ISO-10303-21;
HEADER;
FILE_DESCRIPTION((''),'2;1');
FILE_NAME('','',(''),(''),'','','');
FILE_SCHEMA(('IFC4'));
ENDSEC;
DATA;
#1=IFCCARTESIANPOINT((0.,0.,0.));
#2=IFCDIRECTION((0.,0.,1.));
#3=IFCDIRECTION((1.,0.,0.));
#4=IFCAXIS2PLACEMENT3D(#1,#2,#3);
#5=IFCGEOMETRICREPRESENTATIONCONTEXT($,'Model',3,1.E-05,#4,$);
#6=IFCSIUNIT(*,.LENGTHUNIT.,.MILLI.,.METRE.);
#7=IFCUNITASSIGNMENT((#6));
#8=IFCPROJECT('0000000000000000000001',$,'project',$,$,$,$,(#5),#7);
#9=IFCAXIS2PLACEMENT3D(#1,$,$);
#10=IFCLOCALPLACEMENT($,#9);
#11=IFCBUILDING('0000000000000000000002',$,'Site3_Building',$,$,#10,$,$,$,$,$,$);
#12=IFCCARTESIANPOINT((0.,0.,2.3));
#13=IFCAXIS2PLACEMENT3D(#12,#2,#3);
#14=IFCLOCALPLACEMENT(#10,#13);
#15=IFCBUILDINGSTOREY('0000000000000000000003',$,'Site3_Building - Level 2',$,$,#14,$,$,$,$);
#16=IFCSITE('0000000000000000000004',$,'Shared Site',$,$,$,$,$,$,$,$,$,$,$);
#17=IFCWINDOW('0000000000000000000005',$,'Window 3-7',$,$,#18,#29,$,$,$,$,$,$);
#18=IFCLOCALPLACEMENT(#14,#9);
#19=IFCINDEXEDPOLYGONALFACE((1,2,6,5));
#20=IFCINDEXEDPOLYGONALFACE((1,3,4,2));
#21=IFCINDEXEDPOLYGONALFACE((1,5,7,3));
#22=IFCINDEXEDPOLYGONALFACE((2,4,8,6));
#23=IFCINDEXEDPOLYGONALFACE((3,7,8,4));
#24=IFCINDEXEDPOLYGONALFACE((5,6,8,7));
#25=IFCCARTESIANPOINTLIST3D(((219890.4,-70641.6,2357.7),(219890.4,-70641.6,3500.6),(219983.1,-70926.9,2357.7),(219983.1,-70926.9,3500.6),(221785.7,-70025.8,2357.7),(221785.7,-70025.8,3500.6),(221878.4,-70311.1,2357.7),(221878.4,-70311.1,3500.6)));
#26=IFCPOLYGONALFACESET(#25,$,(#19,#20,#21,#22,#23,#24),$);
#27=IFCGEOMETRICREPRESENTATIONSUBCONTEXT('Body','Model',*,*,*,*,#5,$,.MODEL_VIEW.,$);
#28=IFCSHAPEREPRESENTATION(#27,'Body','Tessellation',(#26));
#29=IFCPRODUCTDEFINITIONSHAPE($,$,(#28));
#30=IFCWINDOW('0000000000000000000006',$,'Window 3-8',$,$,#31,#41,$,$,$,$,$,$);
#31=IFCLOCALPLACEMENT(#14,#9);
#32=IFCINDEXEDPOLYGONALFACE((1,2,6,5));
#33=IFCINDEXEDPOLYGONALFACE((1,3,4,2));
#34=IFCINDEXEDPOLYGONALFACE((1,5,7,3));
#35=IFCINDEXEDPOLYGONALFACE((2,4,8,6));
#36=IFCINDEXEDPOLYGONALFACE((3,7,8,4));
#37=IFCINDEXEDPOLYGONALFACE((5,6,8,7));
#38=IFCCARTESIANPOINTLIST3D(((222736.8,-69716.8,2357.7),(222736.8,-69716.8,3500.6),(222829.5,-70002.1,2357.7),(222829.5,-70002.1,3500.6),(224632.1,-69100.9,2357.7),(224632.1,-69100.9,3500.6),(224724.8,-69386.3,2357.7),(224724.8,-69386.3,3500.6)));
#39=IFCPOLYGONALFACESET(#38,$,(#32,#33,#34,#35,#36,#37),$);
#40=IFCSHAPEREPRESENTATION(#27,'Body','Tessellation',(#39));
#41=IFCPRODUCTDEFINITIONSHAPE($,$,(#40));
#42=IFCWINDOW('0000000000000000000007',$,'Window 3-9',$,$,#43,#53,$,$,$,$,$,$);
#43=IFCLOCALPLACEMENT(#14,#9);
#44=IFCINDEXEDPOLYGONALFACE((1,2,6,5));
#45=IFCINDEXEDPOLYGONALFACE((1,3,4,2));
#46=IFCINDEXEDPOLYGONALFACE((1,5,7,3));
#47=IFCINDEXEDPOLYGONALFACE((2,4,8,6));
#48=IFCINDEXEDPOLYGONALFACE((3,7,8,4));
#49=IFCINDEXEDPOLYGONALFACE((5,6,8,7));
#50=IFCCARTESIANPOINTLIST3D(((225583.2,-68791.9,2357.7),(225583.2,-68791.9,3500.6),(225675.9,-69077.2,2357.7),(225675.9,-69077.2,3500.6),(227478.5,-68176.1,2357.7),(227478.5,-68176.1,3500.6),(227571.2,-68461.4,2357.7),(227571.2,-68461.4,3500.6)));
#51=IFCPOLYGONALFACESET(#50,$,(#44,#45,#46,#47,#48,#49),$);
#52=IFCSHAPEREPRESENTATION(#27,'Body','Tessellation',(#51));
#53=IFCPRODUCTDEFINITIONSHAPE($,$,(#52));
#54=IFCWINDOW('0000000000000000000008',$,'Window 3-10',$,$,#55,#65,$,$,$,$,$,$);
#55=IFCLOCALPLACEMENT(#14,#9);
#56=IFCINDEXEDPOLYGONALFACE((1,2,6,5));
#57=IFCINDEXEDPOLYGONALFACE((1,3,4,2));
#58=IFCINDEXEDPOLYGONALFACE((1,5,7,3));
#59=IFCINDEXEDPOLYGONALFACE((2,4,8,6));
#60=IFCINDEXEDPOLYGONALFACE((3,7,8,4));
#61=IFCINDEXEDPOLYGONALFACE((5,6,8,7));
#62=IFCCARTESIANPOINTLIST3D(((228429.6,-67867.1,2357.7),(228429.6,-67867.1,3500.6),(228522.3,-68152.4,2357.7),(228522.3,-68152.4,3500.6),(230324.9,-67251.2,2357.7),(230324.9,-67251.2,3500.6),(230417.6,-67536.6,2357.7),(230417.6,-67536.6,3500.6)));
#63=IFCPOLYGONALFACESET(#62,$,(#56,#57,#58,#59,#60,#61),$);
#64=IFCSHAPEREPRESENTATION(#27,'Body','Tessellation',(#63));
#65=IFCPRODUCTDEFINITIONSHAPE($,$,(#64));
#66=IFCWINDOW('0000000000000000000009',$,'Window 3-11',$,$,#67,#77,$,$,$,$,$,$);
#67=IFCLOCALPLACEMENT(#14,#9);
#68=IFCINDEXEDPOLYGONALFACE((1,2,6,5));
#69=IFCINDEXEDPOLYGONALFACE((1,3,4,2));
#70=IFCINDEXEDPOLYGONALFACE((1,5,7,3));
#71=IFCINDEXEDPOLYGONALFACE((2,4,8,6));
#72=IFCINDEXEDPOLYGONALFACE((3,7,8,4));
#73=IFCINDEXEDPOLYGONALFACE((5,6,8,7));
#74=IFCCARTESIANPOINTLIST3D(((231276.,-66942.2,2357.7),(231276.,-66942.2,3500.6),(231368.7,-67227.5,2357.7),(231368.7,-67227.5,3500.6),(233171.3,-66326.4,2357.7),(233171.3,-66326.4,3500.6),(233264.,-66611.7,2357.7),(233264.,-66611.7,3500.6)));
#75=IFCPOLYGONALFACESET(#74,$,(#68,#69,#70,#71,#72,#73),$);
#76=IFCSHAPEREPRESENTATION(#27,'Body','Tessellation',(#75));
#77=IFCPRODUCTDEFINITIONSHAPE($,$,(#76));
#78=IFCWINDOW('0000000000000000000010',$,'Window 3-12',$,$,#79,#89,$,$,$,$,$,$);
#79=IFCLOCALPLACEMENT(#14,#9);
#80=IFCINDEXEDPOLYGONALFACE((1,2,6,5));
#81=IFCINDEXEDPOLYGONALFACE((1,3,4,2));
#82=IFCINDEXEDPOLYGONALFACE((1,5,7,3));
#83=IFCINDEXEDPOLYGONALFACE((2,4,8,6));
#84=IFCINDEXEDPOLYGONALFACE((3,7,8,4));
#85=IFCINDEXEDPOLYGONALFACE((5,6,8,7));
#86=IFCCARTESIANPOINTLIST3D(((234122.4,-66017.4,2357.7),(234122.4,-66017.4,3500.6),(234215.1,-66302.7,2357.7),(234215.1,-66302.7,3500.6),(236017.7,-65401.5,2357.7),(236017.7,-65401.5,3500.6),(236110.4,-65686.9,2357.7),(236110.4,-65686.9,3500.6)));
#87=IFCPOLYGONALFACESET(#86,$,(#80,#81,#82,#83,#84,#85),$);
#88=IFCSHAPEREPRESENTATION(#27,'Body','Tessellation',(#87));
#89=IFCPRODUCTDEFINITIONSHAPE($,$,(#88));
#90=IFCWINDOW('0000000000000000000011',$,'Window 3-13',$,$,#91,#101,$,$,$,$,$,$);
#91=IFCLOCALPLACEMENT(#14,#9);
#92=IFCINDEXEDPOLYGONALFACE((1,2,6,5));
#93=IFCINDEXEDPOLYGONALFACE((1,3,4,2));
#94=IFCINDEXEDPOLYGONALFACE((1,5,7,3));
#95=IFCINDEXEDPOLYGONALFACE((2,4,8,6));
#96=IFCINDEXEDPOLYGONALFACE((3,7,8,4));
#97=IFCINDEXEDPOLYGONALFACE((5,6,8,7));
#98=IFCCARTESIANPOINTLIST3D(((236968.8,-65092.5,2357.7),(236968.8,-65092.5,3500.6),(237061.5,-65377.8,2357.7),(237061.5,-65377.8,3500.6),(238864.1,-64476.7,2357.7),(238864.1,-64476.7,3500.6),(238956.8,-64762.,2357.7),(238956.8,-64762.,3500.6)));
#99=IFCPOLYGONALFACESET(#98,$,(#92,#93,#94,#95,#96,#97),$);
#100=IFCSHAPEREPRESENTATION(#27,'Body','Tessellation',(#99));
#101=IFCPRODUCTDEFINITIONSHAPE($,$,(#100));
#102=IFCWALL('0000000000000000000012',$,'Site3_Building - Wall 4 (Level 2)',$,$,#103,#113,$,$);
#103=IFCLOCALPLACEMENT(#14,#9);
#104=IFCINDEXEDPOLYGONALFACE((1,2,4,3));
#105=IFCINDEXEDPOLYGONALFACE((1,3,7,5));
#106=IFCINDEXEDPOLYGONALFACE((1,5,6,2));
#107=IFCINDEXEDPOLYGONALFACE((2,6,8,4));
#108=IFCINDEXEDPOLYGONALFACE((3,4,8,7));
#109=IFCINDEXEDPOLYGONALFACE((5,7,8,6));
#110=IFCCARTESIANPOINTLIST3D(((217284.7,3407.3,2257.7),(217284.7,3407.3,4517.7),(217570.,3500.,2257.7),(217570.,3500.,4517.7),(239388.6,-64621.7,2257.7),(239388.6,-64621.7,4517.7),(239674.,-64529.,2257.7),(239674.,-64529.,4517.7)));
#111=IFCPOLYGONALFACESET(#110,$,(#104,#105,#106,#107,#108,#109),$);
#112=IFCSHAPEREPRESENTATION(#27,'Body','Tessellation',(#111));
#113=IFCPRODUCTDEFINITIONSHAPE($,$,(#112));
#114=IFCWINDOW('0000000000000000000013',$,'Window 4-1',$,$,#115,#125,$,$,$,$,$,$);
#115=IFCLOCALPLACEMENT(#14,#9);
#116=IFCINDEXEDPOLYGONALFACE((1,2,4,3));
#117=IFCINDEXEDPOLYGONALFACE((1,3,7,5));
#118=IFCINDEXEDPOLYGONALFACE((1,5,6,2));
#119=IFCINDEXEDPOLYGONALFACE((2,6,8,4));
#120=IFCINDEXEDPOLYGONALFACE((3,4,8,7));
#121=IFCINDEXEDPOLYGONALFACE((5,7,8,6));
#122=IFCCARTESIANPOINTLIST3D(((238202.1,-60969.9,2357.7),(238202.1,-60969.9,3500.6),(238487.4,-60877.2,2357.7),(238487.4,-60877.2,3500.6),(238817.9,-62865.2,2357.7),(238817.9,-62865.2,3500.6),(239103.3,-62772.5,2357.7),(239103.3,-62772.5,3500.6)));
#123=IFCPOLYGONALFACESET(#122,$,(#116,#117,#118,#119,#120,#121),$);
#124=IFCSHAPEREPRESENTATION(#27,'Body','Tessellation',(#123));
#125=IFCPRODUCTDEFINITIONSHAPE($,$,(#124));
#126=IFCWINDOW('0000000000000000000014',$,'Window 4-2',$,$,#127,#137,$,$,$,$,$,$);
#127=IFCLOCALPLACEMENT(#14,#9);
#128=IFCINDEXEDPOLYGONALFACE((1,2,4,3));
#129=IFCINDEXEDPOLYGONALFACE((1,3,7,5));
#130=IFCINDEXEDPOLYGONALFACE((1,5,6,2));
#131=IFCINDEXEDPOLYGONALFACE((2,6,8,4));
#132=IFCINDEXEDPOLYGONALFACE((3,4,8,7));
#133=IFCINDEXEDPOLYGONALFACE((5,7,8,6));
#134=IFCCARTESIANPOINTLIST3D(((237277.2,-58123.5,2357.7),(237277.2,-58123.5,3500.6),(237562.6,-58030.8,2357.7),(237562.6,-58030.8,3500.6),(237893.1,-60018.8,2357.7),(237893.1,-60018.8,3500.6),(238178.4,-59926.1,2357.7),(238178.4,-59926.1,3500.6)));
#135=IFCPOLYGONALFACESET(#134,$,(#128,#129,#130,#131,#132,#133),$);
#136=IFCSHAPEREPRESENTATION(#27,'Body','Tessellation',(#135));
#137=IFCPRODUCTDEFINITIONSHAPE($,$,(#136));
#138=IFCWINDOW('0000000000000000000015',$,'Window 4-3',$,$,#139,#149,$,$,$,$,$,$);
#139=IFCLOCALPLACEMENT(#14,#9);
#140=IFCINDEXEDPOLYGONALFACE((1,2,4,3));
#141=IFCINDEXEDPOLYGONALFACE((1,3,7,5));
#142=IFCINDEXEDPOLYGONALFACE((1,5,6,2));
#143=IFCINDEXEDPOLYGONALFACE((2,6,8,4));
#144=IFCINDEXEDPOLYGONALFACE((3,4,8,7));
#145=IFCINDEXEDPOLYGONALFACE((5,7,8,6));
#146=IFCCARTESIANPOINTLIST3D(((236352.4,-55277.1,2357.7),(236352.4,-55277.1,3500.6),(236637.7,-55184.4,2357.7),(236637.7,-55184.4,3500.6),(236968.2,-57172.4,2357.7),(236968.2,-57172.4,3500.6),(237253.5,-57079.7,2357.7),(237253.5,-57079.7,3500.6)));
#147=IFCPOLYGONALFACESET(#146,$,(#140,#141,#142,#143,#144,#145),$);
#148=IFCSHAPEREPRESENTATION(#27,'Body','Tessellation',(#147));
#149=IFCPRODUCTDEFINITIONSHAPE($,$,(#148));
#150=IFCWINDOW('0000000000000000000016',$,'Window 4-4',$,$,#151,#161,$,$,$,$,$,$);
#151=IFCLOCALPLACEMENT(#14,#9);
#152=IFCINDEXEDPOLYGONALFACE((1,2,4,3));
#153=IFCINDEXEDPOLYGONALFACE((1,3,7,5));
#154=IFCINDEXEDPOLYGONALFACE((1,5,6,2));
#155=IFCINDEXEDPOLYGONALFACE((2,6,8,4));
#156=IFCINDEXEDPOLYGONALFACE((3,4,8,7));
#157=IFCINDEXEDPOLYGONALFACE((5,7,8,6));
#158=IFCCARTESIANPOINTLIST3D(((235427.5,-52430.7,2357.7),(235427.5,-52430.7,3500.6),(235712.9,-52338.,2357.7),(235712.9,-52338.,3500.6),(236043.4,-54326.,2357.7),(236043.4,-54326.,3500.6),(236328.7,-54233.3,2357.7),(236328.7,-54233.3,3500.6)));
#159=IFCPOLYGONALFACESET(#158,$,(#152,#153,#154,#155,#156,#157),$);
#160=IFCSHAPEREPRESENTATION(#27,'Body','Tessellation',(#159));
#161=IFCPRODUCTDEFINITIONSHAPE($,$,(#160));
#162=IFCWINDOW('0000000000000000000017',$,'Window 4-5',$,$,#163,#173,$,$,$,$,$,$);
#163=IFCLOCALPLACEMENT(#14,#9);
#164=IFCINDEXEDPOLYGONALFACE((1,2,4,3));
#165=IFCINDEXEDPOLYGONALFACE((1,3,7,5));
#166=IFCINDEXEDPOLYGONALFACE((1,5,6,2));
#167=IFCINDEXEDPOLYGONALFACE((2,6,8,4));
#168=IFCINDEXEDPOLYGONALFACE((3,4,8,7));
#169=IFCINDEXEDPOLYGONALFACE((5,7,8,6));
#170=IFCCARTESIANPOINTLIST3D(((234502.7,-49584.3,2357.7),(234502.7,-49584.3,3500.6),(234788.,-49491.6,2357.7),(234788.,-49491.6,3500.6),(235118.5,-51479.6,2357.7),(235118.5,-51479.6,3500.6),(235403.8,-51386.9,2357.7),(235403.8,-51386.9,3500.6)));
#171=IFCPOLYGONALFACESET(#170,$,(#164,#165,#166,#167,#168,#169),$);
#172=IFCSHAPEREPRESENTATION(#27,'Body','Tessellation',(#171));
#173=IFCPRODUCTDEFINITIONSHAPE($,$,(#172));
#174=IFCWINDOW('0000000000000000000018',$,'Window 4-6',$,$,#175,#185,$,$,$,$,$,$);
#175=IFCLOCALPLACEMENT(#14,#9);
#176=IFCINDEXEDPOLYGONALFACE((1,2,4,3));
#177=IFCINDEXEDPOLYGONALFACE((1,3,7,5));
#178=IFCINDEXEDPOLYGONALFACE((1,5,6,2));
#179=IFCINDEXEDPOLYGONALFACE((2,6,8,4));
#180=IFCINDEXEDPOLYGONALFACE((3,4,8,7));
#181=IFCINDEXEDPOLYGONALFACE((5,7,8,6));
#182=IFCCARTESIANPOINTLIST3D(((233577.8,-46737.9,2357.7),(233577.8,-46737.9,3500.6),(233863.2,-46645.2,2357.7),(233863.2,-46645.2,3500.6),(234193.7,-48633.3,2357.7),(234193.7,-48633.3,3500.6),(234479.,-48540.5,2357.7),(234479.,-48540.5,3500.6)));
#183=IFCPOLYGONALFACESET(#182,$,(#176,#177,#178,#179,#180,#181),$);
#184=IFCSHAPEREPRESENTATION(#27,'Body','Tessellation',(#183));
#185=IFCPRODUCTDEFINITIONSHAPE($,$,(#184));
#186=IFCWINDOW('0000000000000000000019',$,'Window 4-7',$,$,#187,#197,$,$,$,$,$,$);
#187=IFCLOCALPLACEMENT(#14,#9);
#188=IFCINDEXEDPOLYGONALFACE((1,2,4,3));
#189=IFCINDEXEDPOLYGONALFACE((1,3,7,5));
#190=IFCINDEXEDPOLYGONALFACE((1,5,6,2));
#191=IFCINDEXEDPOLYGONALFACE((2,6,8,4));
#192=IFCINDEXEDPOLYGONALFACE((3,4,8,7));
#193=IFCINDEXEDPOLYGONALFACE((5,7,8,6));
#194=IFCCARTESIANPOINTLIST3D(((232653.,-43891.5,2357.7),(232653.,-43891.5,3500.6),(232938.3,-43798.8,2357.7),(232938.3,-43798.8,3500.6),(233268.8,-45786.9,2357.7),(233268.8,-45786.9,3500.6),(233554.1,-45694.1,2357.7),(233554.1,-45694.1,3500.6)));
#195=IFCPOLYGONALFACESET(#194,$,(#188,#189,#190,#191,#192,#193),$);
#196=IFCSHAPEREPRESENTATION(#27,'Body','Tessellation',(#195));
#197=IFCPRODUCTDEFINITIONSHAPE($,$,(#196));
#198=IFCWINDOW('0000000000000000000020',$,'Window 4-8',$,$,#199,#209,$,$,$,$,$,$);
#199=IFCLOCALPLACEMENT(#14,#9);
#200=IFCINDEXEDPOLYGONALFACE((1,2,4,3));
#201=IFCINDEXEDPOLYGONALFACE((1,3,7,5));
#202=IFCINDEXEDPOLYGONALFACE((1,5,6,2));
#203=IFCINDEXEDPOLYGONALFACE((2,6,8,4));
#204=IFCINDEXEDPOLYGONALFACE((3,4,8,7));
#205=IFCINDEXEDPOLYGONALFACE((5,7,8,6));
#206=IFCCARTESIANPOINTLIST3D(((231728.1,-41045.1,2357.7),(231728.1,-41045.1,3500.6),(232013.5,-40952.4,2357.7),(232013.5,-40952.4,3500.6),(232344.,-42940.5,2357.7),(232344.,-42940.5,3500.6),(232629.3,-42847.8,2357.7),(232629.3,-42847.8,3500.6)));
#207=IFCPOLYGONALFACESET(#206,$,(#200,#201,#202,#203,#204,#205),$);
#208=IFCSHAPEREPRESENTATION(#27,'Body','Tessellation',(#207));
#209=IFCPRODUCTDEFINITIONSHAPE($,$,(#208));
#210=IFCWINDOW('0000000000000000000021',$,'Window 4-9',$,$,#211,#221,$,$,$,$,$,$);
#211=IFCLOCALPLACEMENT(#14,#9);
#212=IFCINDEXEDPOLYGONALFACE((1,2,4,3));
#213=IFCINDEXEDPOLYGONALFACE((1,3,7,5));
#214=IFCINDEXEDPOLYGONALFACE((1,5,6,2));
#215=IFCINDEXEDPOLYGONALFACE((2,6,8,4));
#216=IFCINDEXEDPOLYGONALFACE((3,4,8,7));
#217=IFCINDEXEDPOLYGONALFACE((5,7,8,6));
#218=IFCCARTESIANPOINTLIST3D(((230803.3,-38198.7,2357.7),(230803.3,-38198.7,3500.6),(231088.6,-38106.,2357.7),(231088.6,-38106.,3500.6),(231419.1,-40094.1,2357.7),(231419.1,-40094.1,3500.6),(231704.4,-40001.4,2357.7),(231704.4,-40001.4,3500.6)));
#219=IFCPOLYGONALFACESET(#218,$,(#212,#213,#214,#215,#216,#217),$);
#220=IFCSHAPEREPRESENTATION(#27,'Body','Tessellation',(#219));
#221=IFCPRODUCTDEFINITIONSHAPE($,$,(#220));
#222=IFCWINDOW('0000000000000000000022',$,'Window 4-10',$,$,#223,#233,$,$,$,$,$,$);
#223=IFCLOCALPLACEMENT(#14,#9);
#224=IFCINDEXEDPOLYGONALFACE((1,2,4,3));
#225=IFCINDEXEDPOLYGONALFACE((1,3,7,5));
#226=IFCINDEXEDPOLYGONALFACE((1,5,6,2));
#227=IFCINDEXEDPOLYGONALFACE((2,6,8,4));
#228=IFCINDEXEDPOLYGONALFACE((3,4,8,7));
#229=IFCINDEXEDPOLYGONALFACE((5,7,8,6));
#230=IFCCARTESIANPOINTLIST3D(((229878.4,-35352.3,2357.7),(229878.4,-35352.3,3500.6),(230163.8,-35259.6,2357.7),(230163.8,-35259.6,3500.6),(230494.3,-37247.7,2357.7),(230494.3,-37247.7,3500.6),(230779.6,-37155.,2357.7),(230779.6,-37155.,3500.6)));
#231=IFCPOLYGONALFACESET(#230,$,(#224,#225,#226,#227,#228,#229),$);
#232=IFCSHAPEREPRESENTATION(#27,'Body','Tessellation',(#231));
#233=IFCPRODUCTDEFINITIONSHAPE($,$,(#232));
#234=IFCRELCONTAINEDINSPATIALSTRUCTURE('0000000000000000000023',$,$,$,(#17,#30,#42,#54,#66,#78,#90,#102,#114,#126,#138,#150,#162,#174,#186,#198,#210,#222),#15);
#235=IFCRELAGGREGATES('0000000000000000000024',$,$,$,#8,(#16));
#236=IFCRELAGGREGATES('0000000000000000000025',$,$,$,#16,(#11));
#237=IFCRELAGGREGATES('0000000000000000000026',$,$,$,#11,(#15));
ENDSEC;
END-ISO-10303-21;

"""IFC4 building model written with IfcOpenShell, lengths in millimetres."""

from ifc_helpers import new_model, si_unit, frame, origin, origin_with_axes, place, context, subcontext, project, spatial, indexed_curve, outline, extrude, element, save


model = new_model("IFC4")

# Units and contexts
model_context = context("Model", 3, precision=1e-05, world=origin_with_axes())
body_context = subcontext(model_context, "Body", "Model", "MODEL_VIEW")
ifc_project = project(units=[si_unit("LENGTHUNIT", "METRE", prefix="MILLI")], contexts=[model_context])

# Site, building, storey
site = spatial("IfcSite", under=ifc_project, Name="Shared Site")
building_placement = place(None, origin())
building = spatial("IfcBuilding", under=site, at=building_placement, Name="Site3_Building")
storey_placement = place(building_placement, frame((0.0, 0.0, 2.3), z_axis=(0.0, 0.0, 1.0), x_axis=(1.0, 0.0, 0.0)))
storey = spatial("IfcBuildingStorey", under=building, at=storey_placement, Name="Site3_Building - Level 2")

# Windows
for number, where, z_axis, x_axis, name in (
    (1, (219983.1, -70926.9, 2357.7), (0.0, 0.0, 1.0), (0.951057, 0.309017, 0.0), "Window 3-7"),
    (2, (222829.5, -70002.1, 2357.7), (0.0, 0.0, 1.0), (0.951057, 0.309017, 0.0), "Window 3-8"),
    (3, (225675.9, -69077.2, 2357.7), (0.0, 0.0, 1.0), (0.951057, 0.309017, 0.0), "Window 3-9"),
    (4, (228522.3, -68152.4, 2357.7), (0.0, 0.0, 1.0), (0.951057, 0.309017, 0.0), "Window 3-10"),
    (5, (231368.7, -67227.5, 2357.7), (0.0, 0.0, 1.0), (0.951057, 0.309017, 0.0), "Window 3-11"),
    (6, (234215.1, -66302.7, 2357.7), (0.0, 0.0, 1.0), (0.951057, 0.309017, 0.0), "Window 3-12"),
    (7, (237061.5, -65377.8, 2357.7), (0.0, 0.0, 1.0), (0.951057, 0.309017, 0.0), "Window 3-13"),
):
    element("IfcWindow", number, at=place(storey_placement, frame(where, z_axis=z_axis, x_axis=x_axis)), inside=storey, Name=name, context=body_context, shape_type="SweptSolid", body=[
        extrude(outline(indexed_curve([(0.0, 0.0), (0.0, 300.0), (1992.9, 300.0), (1992.9, 0.0), (0.0, 0.0)], self_intersect=False)), origin_with_axes(), (0.0, 0.0, 1.0), 1142.8),
    ])

# Wall
wall_1_placement = place(storey_placement, frame((239674.0, -64529.0, 2257.7), z_axis=(0.0, 0.0, 1.0), x_axis=(-0.309017, 0.951057, 0.0)))
element("IfcWall", 8, at=wall_1_placement, inside=storey, Name="Site3_Building - Wall 4 (Level 2)", context=body_context, shape_type="SweptSolid", body=[
    extrude(outline(indexed_curve([(0.0, 0.0), (0.0, 300.0), (71529.9, 300.0), (71529.9, 0.0), (0.0, 0.0)], self_intersect=False)), origin_with_axes(), (0.0, 0.0, 1.0), 2260.0),
])

# Windows
for number, where, z_axis, x_axis, name in (
    (9, (239103.3, -62772.5, 2357.7), (0.0, 0.0, 1.0), (-0.309017, 0.951057, 0.0), "Window 4-1"),
    (10, (238178.4, -59926.1, 2357.7), (0.0, 0.0, 1.0), (-0.309017, 0.951057, 0.0), "Window 4-2"),
    (11, (237253.5, -57079.7, 2357.7), (0.0, 0.0, 1.0), (-0.309017, 0.951057, 0.0), "Window 4-3"),
    (12, (236328.7, -54233.3, 2357.7), (0.0, 0.0, 1.0), (-0.309017, 0.951057, 0.0), "Window 4-4"),
    (13, (235403.8, -51386.9, 2357.7), (0.0, 0.0, 1.0), (-0.309017, 0.951057, 0.0), "Window 4-5"),
    (14, (234479.0, -48540.5, 2357.7), (0.0, 0.0, 1.0), (-0.309017, 0.951057, 0.0), "Window 4-6"),
    (15, (233554.1, -45694.1, 2357.7), (0.0, 0.0, 1.0), (-0.309017, 0.951057, 0.0), "Window 4-7"),
    (16, (232629.3, -42847.8, 2357.7), (0.0, 0.0, 1.0), (-0.309017, 0.951057, 0.0), "Window 4-8"),
    (17, (231704.4, -40001.4, 2357.7), (0.0, 0.0, 1.0), (-0.309017, 0.951057, 0.0), "Window 4-9"),
    (18, (230779.6, -37155.0, 2357.7), (0.0, 0.0, 1.0), (-0.309017, 0.951057, 0.0), "Window 4-10"),
):
    element("IfcWindow", number, at=place(storey_placement, frame(where, z_axis=z_axis, x_axis=x_axis)), inside=storey, Name=name, context=body_context, shape_type="SweptSolid", body=[
        extrude(outline(indexed_curve([(0.0, 0.0), (0.0, 300.0), (1992.9, 300.0), (1992.9, 0.0), (0.0, 0.0)], self_intersect=False)), origin_with_axes(), (0.0, 0.0, 1.0), 1142.8),
    ])

save(model, "model.ifc")
